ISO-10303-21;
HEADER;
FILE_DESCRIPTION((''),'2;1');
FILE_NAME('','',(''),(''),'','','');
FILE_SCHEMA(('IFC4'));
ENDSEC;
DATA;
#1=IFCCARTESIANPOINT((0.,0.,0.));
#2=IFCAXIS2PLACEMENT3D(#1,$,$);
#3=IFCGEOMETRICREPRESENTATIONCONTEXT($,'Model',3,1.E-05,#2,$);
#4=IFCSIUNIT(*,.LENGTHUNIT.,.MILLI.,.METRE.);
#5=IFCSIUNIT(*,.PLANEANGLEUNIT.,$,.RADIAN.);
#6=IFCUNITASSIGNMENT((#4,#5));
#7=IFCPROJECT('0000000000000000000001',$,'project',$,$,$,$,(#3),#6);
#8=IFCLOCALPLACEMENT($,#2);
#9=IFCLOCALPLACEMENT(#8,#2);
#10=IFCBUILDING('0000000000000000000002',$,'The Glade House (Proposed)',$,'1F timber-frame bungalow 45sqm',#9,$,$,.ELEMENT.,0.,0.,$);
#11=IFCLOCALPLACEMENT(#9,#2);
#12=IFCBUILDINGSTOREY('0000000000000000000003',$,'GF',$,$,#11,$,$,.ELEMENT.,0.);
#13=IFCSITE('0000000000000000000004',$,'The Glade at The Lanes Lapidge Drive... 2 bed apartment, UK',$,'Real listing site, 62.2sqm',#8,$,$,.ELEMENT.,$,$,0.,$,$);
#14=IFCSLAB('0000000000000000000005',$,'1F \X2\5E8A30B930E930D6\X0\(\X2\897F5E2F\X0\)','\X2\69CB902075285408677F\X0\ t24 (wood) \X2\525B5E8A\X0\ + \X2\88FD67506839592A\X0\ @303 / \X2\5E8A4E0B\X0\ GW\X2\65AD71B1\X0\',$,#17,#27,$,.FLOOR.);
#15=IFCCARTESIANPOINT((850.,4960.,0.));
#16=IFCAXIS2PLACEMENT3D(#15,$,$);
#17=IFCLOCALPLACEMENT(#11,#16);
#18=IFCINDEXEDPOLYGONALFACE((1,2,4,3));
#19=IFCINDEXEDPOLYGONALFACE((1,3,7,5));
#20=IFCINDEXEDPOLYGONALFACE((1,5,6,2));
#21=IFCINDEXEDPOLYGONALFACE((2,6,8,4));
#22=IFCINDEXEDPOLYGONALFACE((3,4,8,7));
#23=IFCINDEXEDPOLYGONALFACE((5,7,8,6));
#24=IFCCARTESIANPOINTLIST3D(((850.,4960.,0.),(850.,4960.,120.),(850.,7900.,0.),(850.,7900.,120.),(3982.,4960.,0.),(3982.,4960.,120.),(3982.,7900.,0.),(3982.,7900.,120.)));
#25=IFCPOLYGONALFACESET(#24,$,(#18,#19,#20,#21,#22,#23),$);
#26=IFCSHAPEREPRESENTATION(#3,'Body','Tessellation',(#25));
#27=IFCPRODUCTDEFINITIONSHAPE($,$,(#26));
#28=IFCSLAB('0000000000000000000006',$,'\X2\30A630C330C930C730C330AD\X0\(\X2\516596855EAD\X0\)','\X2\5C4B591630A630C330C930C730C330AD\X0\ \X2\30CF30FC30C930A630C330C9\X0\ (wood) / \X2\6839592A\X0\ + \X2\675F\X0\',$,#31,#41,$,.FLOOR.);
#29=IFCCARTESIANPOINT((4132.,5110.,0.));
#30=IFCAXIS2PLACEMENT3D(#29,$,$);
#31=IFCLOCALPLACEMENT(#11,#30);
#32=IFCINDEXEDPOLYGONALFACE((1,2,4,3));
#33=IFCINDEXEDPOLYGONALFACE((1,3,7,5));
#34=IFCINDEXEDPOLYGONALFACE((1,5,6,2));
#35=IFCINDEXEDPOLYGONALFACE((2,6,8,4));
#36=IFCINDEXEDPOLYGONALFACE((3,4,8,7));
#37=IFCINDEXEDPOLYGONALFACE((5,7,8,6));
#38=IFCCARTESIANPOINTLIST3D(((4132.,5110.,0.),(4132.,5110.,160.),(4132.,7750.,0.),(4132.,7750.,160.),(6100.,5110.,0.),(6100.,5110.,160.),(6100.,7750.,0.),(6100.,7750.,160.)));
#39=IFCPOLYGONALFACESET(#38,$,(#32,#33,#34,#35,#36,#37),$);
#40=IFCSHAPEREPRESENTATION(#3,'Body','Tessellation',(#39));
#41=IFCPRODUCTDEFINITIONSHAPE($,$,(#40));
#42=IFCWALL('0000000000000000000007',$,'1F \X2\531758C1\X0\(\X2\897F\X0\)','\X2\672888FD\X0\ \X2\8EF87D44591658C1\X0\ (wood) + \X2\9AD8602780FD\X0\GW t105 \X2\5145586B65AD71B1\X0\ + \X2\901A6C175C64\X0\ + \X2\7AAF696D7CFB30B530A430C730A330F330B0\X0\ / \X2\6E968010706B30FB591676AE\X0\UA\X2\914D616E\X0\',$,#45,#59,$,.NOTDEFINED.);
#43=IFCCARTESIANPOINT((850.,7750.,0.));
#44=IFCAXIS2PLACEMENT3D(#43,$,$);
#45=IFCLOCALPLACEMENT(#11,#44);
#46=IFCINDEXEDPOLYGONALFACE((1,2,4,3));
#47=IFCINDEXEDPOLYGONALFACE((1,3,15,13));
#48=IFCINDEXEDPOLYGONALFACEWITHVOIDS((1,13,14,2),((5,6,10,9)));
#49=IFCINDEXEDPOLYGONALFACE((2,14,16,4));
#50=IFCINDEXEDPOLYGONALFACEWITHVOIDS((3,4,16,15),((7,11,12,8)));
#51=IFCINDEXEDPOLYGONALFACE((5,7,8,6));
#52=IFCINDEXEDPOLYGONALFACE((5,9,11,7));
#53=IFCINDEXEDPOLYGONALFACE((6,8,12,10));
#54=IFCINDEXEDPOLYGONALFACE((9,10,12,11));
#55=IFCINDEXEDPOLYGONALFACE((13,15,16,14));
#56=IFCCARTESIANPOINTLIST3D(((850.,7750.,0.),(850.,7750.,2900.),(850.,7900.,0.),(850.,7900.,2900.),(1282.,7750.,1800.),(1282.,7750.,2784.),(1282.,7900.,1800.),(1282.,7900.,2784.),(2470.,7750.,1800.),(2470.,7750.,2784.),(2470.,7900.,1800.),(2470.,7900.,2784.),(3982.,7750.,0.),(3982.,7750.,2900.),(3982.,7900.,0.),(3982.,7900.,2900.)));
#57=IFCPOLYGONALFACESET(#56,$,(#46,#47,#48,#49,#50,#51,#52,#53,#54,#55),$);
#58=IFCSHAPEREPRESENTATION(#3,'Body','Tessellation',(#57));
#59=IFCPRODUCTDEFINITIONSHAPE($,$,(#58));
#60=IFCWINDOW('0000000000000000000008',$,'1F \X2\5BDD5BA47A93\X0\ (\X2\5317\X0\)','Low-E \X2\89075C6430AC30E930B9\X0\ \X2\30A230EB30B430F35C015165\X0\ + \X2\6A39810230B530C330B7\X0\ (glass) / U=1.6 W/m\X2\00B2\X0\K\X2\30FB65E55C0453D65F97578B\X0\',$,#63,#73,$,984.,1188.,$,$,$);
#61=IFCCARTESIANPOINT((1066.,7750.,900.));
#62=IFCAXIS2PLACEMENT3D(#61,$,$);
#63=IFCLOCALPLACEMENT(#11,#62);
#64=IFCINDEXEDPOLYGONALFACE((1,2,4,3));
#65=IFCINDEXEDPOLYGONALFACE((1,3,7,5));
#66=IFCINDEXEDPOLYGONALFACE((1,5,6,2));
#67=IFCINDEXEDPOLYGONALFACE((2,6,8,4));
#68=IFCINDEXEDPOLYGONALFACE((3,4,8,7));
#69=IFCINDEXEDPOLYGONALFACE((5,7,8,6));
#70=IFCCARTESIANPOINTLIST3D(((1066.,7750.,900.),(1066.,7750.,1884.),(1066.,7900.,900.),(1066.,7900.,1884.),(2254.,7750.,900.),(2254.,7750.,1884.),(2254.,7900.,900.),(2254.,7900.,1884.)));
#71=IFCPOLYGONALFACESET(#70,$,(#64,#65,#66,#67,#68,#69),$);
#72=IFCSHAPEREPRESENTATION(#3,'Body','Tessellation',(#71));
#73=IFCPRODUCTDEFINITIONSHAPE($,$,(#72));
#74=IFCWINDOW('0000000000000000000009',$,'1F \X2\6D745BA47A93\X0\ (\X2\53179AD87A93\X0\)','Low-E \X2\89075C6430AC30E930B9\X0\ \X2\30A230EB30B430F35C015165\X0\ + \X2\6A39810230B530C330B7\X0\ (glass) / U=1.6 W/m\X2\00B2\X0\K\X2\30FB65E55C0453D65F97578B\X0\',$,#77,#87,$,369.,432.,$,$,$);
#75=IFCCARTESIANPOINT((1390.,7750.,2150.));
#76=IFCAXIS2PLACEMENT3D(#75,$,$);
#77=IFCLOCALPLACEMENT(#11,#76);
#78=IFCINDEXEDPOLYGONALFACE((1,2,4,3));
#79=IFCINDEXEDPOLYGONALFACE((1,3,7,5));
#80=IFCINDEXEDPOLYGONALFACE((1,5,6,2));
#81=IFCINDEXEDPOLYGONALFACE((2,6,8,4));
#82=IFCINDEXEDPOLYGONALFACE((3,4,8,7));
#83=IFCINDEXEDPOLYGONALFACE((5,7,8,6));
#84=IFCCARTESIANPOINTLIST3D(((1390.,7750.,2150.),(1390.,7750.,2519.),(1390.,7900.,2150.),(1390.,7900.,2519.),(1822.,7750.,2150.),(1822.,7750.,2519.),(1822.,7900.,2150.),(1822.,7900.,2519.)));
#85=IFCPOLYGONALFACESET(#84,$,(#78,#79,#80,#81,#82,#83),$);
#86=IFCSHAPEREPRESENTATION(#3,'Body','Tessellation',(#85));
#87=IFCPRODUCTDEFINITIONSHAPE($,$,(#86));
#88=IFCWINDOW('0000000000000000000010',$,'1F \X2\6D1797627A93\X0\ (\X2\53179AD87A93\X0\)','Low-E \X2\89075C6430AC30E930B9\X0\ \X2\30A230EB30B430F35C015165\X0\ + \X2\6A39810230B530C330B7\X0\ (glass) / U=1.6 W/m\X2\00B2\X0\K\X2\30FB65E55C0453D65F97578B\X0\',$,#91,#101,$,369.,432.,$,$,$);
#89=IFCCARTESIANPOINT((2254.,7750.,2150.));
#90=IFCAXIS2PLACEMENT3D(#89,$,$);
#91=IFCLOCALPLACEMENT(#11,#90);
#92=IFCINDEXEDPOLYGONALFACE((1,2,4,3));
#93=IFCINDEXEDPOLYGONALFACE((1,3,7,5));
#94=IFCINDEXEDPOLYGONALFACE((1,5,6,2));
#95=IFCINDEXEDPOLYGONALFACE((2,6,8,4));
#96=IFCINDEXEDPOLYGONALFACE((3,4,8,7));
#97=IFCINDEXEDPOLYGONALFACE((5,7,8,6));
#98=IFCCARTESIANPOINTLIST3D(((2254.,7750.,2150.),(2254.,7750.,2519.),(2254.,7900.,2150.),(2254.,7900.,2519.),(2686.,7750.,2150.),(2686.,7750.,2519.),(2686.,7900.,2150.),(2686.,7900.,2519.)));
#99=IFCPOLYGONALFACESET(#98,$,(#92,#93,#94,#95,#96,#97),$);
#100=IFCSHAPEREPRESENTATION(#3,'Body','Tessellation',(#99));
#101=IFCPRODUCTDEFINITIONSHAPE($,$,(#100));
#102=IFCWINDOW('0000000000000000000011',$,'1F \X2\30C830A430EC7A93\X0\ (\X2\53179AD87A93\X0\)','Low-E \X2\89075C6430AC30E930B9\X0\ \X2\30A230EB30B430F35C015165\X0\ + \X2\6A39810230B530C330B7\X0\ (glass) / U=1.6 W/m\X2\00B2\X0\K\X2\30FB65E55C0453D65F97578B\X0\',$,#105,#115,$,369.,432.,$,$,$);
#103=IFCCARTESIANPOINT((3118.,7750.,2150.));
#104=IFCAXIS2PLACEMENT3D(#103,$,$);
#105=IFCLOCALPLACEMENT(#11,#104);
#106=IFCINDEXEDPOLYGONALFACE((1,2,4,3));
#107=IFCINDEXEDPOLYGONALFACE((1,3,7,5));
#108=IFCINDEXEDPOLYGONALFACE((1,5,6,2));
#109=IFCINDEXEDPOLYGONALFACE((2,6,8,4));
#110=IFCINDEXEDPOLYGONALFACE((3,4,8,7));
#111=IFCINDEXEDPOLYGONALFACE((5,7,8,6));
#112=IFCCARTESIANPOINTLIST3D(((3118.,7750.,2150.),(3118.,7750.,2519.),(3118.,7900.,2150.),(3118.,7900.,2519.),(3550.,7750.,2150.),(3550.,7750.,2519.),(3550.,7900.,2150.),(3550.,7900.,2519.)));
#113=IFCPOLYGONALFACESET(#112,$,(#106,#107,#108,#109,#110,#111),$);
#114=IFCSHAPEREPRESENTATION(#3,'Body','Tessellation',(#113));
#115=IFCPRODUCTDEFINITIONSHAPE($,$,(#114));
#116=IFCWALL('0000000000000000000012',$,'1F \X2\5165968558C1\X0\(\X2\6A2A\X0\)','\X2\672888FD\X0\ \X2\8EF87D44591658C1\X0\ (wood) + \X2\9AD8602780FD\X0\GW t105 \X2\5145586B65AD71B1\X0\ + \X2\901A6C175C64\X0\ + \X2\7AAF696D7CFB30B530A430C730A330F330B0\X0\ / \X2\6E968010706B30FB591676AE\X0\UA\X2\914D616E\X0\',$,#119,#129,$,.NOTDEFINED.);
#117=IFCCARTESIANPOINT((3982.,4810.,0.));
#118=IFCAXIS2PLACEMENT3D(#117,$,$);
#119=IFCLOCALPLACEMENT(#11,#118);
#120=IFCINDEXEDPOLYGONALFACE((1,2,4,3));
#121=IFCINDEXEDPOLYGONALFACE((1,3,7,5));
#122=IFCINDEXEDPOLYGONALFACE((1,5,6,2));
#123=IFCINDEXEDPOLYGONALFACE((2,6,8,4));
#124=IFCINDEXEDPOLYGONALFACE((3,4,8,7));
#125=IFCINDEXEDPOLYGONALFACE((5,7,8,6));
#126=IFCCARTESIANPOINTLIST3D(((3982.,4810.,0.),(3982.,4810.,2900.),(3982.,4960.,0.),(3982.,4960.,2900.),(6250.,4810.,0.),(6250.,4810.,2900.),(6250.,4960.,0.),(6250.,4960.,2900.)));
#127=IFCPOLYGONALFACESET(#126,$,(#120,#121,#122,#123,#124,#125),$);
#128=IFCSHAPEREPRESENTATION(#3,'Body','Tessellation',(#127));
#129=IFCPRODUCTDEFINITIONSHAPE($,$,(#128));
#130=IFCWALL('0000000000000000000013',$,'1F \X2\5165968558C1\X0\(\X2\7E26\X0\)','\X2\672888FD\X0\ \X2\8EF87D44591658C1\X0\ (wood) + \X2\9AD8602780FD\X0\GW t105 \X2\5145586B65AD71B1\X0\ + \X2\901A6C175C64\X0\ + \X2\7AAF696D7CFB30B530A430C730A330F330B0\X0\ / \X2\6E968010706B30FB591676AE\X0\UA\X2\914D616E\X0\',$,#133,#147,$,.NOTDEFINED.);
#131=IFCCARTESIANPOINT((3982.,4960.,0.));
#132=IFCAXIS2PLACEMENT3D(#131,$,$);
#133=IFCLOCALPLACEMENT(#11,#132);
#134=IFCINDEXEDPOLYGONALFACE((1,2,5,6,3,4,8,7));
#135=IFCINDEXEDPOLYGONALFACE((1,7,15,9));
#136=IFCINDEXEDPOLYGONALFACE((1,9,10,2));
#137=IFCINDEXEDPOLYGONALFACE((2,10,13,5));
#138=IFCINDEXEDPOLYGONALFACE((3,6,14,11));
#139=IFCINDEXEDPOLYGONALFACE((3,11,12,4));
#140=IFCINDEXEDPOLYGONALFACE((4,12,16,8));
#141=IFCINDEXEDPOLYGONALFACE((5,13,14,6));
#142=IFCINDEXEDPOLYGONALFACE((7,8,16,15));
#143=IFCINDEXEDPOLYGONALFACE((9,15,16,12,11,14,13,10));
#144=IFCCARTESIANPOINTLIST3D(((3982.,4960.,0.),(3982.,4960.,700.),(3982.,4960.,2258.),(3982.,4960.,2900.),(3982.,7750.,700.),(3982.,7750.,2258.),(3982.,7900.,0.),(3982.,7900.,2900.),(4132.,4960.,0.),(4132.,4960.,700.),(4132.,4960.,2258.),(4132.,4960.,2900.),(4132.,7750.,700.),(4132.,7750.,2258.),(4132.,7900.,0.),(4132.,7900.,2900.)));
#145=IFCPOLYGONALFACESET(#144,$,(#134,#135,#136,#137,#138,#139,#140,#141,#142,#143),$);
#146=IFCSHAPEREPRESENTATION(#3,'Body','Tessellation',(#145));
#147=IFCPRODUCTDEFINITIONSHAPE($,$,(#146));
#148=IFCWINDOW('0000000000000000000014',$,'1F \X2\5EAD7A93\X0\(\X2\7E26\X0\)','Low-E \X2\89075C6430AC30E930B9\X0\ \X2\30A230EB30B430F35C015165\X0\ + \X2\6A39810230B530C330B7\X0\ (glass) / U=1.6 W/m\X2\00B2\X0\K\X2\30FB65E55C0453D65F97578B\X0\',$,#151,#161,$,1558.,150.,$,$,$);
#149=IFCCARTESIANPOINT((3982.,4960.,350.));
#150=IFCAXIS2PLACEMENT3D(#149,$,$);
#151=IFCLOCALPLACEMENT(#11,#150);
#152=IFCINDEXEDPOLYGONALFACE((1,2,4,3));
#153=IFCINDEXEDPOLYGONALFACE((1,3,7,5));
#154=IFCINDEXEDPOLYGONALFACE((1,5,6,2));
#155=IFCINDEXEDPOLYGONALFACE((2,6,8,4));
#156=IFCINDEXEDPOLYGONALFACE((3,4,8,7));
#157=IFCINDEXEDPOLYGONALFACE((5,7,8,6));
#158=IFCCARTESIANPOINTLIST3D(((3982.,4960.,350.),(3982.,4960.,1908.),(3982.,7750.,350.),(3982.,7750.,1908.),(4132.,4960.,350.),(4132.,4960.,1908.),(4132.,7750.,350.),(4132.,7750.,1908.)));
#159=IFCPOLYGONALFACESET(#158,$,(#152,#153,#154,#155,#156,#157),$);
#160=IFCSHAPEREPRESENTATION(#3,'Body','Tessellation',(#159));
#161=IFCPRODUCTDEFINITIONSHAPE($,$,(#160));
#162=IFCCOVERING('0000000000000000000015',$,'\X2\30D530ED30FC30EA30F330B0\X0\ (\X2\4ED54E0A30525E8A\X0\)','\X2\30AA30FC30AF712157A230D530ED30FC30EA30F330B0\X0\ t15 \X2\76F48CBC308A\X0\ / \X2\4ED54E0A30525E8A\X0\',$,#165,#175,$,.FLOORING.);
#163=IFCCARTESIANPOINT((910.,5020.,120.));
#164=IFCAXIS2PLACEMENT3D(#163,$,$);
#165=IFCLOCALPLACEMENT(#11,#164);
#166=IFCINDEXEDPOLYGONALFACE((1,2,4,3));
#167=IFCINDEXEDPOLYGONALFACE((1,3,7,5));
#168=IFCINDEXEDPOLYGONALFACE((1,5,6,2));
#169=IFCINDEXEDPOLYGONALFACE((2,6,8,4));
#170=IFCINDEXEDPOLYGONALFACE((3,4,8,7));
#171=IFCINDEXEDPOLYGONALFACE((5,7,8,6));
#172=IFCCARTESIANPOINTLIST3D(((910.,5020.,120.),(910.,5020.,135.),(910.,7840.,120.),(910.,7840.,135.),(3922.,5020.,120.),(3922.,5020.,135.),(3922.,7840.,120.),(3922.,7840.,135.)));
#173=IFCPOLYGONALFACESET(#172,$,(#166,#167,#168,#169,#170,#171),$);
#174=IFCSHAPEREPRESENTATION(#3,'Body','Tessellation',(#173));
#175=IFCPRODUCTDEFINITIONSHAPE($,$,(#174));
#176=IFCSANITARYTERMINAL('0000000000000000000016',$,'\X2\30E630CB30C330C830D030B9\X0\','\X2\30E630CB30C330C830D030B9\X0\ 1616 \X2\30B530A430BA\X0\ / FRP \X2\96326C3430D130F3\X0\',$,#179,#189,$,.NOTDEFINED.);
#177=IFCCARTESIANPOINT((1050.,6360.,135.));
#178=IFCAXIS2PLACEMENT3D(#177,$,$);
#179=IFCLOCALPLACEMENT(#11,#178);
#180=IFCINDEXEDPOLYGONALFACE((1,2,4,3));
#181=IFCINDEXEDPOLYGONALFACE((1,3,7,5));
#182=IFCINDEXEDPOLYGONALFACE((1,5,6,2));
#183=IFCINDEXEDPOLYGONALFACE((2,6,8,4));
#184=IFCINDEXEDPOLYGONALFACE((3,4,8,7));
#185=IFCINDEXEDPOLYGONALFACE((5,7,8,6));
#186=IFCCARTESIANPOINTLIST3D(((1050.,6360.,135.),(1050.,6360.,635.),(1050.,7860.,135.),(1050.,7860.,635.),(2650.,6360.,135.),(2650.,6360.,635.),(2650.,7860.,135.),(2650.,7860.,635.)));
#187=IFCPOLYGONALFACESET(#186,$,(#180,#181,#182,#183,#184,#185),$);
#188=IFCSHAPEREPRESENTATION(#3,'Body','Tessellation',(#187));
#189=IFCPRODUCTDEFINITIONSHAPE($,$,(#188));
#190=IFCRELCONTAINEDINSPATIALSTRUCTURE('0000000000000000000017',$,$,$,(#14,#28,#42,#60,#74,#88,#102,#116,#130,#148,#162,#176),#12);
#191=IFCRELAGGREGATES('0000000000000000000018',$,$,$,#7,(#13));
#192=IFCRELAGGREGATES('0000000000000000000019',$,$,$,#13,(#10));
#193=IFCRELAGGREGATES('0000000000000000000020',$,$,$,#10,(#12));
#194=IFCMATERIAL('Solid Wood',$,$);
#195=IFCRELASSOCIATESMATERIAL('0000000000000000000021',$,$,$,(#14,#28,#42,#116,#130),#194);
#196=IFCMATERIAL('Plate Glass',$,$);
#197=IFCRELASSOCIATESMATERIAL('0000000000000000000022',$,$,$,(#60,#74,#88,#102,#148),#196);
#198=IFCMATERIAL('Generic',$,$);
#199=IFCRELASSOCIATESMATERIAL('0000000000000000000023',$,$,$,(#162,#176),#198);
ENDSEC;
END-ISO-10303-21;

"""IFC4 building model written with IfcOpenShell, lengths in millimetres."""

from ifc_helpers import new_model, si_unit, frame, frame_2d, origin, place, context, project, spatial, rectangle, extrude, material, element, fill, save


model = new_model("IFC4")

# Units and contexts
model_context = context("Model", 3, precision=1e-05, world=origin())
ifc_project = project(units=[si_unit("LENGTHUNIT", "METRE", prefix="MILLI"), si_unit("PLANEANGLEUNIT", "RADIAN")], contexts=[model_context])

# Site, building, storey
site_placement = place(None, origin())
site = spatial("IfcSite", under=ifc_project, at=site_placement, Name="The Glade at The Lanes Lapidge Drive... 2 bed apartment, UK", ObjectType="Real listing site, 62.2sqm", CompositionType="ELEMENT", RefElevation=0.0)
building_placement = place(site_placement, origin())
building = spatial("IfcBuilding", under=site, at=building_placement, Name="The Glade House (Proposed)", ObjectType="1F timber-frame bungalow 45sqm", CompositionType="ELEMENT", ElevationOfRefHeight=0.0, ElevationOfTerrain=0.0)
storey_placement = place(building_placement, origin())
storey = spatial("IfcBuildingStorey", under=building, at=storey_placement, Name="GF", CompositionType="ELEMENT", Elevation=0.0)

# Slabs
ifc_material_1 = material(Name="Solid Wood")
slab_1_placement = place(storey_placement, frame((850.0, 4960.0, 0.0)))
element("IfcSlab", 1, at=slab_1_placement, inside=storey, material=ifc_material_1, Name="1F 床スラブ(西帯)", Description="構造用合板 t24 (wood) 剛床 + 製材根太 @303 / 床下 GW断熱", PredefinedType="FLOOR", context=model_context, shape_type="SweptSolid", body=[
    extrude(rectangle(XDim=3132.0, YDim=2940.0, at=frame_2d((1566.0, 1470.0))), frame((850.0, 4960.0, 0.0)), (0.0, 0.0, 1.0), 120.0),
])
slab_2_placement = place(storey_placement, frame((4132.0, 5110.0, 0.0)))
element("IfcSlab", 2, at=slab_2_placement, inside=storey, material=ifc_material_1, Name="ウッドデッキ(入隅庭)", Description="屋外ウッドデッキ ハードウッド (wood) / 根太 + 束", PredefinedType="FLOOR", context=model_context, shape_type="SweptSolid", body=[
    extrude(rectangle(XDim=1968.0, YDim=2640.0, at=frame_2d((984.0, 1320.0))), frame((4132.0, 5110.0, 0.0)), (0.0, 0.0, 1.0), 160.0),
])

# Wall, openings, windows
wall_1_placement = place(storey_placement, frame((850.0, 7750.0, 0.0)))
wall_1 = element("IfcWall", 3, at=wall_1_placement, inside=storey, material=ifc_material_1, Name="1F 北壁(西)", Description="木製 軸組外壁 (wood) + 高性能GW t105 充填断熱 + 通気層 + 窯業系サイディング / 準耐火・外皮UA配慮", PredefinedType="NOTDEFINED", context=model_context, shape_type="SweptSolid", body=[
    extrude(rectangle(XDim=3132.0, YDim=150.0, at=frame_2d((1566.0, 75.0))), frame((850.0, 7750.0, 0.0)), (0.0, 0.0, 1.0), 2900.0),
])
opening_1_placement = place(storey_placement, frame((1066.0, 7750.0, 900.0)))
opening_1 = element("IfcOpeningElement", 4, at=opening_1_placement, cuts=wall_1, PredefinedType="NOTDEFINED", context=model_context, shape_type="SweptSolid", body=[
    extrude(rectangle(XDim=1188.0, YDim=150.0, at=frame_2d((594.0, 75.0))), frame((1066.0, 7750.0, 900.0)), (0.0, 0.0, 1.0), 984.0),
])
opening_2_placement = place(storey_placement, frame((1390.0, 7750.0, 2150.0)))
opening_2 = element("IfcOpeningElement", 5, at=opening_2_placement, cuts=wall_1, PredefinedType="NOTDEFINED", context=model_context, shape_type="SweptSolid", body=[
    extrude(rectangle(XDim=432.0, YDim=150.0, at=frame_2d((216.0, 75.0))), frame((1390.0, 7750.0, 2150.0)), (0.0, 0.0, 1.0), 369.0),
])
opening_3_placement = place(storey_placement, frame((2254.0, 7750.0, 2150.0)))
opening_3 = element("IfcOpeningElement", 6, at=opening_3_placement, cuts=wall_1, PredefinedType="NOTDEFINED", context=model_context, shape_type="SweptSolid", body=[
    extrude(rectangle(XDim=432.0, YDim=150.0, at=frame_2d((216.0, 75.0))), frame((2254.0, 7750.0, 2150.0)), (0.0, 0.0, 1.0), 369.0),
])
opening_4_placement = place(storey_placement, frame((3118.0, 7750.0, 2150.0)))
opening_4 = element("IfcOpeningElement", 7, at=opening_4_placement, cuts=wall_1, PredefinedType="NOTDEFINED", context=model_context, shape_type="SweptSolid", body=[
    extrude(rectangle(XDim=432.0, YDim=150.0, at=frame_2d((216.0, 75.0))), frame((3118.0, 7750.0, 2150.0)), (0.0, 0.0, 1.0), 369.0),
])
ifc_material_2 = material(Name="Plate Glass")
window_1_placement = place(storey_placement, frame((1066.0, 7750.0, 900.0)))
window_1 = element("IfcWindow", 8, at=window_1_placement, inside=storey, material=ifc_material_2, Name="1F 寝室窓 (北)", Description="Low-E 複層ガラス アルゴン封入 + 樹脂サッシ (glass) / U=1.6 W/m²K・日射取得型", OverallHeight=984.0, OverallWidth=1188.0, context=model_context, shape_type="SweptSolid", body=[
    extrude(rectangle(XDim=1188.0, YDim=150.0, at=frame_2d((594.0, 75.0))), frame((1066.0, 7750.0, 900.0)), (0.0, 0.0, 1.0), 984.0),
])
fill(opening_1, window_1)
window_2_placement = place(storey_placement, frame((1390.0, 7750.0, 2150.0)))
window_2 = element("IfcWindow", 9, at=window_2_placement, inside=storey, material=ifc_material_2, Name="1F 浴室窓 (北高窓)", Description="Low-E 複層ガラス アルゴン封入 + 樹脂サッシ (glass) / U=1.6 W/m²K・日射取得型", OverallHeight=369.0, OverallWidth=432.0, context=model_context, shape_type="SweptSolid", body=[
    extrude(rectangle(XDim=432.0, YDim=150.0, at=frame_2d((216.0, 75.0))), frame((1390.0, 7750.0, 2150.0)), (0.0, 0.0, 1.0), 369.0),
])
fill(opening_2, window_2)
window_3_placement = place(storey_placement, frame((2254.0, 7750.0, 2150.0)))
window_3 = element("IfcWindow", 10, at=window_3_placement, inside=storey, material=ifc_material_2, Name="1F 洗面窓 (北高窓)", Description="Low-E 複層ガラス アルゴン封入 + 樹脂サッシ (glass) / U=1.6 W/m²K・日射取得型", OverallHeight=369.0, OverallWidth=432.0, context=model_context, shape_type="SweptSolid", body=[
    extrude(rectangle(XDim=432.0, YDim=150.0, at=frame_2d((216.0, 75.0))), frame((2254.0, 7750.0, 2150.0)), (0.0, 0.0, 1.0), 369.0),
])
fill(opening_3, window_3)
window_4_placement = place(storey_placement, frame((3118.0, 7750.0, 2150.0)))
window_4 = element("IfcWindow", 11, at=window_4_placement, inside=storey, material=ifc_material_2, Name="1F トイレ窓 (北高窓)", Description="Low-E 複層ガラス アルゴン封入 + 樹脂サッシ (glass) / U=1.6 W/m²K・日射取得型", OverallHeight=369.0, OverallWidth=432.0, context=model_context, shape_type="SweptSolid", body=[
    extrude(rectangle(XDim=432.0, YDim=150.0, at=frame_2d((216.0, 75.0))), frame((3118.0, 7750.0, 2150.0)), (0.0, 0.0, 1.0), 369.0),
])
fill(opening_4, window_4)

# Wall
wall_2_placement = place(storey_placement, frame((3982.0, 4810.0, 0.0)))
element("IfcWall", 12, at=wall_2_placement, inside=storey, material=ifc_material_1, Name="1F 入隅壁(横)", Description="木製 軸組外壁 (wood) + 高性能GW t105 充填断熱 + 通気層 + 窯業系サイディング / 準耐火・外皮UA配慮", PredefinedType="NOTDEFINED", context=model_context, shape_type="SweptSolid", body=[
    extrude(rectangle(XDim=2268.0, YDim=150.0, at=frame_2d((1134.0, 75.0))), frame((3982.0, 4810.0, 0.0)), (0.0, 0.0, 1.0), 2900.0),
])

# Wall, opening, window
wall_3_placement = place(storey_placement, frame((3982.0, 4960.0, 0.0)))
wall_3 = element("IfcWall", 13, at=wall_3_placement, inside=storey, material=ifc_material_1, Name="1F 入隅壁(縦)", Description="木製 軸組外壁 (wood) + 高性能GW t105 充填断熱 + 通気層 + 窯業系サイディング / 準耐火・外皮UA配慮", PredefinedType="NOTDEFINED", context=model_context, shape_type="SweptSolid", body=[
    extrude(rectangle(XDim=150.0, YDim=2940.0, at=frame_2d((75.0, 1470.0))), frame((3982.0, 4960.0, 0.0)), (0.0, 0.0, 1.0), 2900.0),
])
opening_5_placement = place(storey_placement, frame((3982.0, 4960.0, 350.0)))
opening_5 = element("IfcOpeningElement", 14, at=opening_5_placement, cuts=wall_3, PredefinedType="NOTDEFINED", context=model_context, shape_type="SweptSolid", body=[
    extrude(rectangle(XDim=150.0, YDim=2790.0, at=frame_2d((75.0, 1395.0))), frame((3982.0, 4960.0, 350.0)), (0.0, 0.0, 1.0), 1558.0),
])
window_5_placement = place(storey_placement, frame((3982.0, 4960.0, 350.0)))
window_5 = element("IfcWindow", 15, at=window_5_placement, inside=storey, material=ifc_material_2, Name="1F 庭窓(縦)", Description="Low-E 複層ガラス アルゴン封入 + 樹脂サッシ (glass) / U=1.6 W/m²K・日射取得型", OverallHeight=1558.0, OverallWidth=150.0, context=model_context, shape_type="SweptSolid", body=[
    extrude(rectangle(XDim=150.0, YDim=2790.0, at=frame_2d((75.0, 1395.0))), frame((3982.0, 4960.0, 350.0)), (0.0, 0.0, 1.0), 1558.0),
])
fill(opening_5, window_5)

# Covering
ifc_material_3 = material(Name="Generic")
covering_placement = place(storey_placement, frame((910.0, 5020.0, 120.0)))
element("IfcCovering", 16, at=covering_placement, inside=storey, material=ifc_material_3, Name="フローリング (仕上げ床)", Description="オーク無垢フローリング t15 直貼り / 仕上げ床", PredefinedType="FLOORING", context=model_context, shape_type="SweptSolid", body=[
    extrude(rectangle(XDim=3012.0, YDim=2820.0, at=frame_2d((1506.0, 1410.0))), frame((910.0, 5020.0, 120.0)), (0.0, 0.0, 1.0), 15.0),
])

# Sanitary terminal
sanitary_terminal_1_placement = place(storey_placement, frame((1050.0, 6360.0, 135.0)))
element("IfcSanitaryTerminal", 17, at=sanitary_terminal_1_placement, inside=storey, material=ifc_material_3, Name="ユニットバス", Description="ユニットバス 1616 サイズ / FRP 防水パン", PredefinedType="NOTDEFINED", context=model_context, shape_type="SweptSolid", body=[
    extrude(rectangle(XDim=1600.0, YDim=1500.0, at=frame_2d((800.0, 750.0))), frame((1050.0, 6360.0, 135.0)), (0.0, 0.0, 1.0), 500.0),
])

save(model, "model.ifc")
